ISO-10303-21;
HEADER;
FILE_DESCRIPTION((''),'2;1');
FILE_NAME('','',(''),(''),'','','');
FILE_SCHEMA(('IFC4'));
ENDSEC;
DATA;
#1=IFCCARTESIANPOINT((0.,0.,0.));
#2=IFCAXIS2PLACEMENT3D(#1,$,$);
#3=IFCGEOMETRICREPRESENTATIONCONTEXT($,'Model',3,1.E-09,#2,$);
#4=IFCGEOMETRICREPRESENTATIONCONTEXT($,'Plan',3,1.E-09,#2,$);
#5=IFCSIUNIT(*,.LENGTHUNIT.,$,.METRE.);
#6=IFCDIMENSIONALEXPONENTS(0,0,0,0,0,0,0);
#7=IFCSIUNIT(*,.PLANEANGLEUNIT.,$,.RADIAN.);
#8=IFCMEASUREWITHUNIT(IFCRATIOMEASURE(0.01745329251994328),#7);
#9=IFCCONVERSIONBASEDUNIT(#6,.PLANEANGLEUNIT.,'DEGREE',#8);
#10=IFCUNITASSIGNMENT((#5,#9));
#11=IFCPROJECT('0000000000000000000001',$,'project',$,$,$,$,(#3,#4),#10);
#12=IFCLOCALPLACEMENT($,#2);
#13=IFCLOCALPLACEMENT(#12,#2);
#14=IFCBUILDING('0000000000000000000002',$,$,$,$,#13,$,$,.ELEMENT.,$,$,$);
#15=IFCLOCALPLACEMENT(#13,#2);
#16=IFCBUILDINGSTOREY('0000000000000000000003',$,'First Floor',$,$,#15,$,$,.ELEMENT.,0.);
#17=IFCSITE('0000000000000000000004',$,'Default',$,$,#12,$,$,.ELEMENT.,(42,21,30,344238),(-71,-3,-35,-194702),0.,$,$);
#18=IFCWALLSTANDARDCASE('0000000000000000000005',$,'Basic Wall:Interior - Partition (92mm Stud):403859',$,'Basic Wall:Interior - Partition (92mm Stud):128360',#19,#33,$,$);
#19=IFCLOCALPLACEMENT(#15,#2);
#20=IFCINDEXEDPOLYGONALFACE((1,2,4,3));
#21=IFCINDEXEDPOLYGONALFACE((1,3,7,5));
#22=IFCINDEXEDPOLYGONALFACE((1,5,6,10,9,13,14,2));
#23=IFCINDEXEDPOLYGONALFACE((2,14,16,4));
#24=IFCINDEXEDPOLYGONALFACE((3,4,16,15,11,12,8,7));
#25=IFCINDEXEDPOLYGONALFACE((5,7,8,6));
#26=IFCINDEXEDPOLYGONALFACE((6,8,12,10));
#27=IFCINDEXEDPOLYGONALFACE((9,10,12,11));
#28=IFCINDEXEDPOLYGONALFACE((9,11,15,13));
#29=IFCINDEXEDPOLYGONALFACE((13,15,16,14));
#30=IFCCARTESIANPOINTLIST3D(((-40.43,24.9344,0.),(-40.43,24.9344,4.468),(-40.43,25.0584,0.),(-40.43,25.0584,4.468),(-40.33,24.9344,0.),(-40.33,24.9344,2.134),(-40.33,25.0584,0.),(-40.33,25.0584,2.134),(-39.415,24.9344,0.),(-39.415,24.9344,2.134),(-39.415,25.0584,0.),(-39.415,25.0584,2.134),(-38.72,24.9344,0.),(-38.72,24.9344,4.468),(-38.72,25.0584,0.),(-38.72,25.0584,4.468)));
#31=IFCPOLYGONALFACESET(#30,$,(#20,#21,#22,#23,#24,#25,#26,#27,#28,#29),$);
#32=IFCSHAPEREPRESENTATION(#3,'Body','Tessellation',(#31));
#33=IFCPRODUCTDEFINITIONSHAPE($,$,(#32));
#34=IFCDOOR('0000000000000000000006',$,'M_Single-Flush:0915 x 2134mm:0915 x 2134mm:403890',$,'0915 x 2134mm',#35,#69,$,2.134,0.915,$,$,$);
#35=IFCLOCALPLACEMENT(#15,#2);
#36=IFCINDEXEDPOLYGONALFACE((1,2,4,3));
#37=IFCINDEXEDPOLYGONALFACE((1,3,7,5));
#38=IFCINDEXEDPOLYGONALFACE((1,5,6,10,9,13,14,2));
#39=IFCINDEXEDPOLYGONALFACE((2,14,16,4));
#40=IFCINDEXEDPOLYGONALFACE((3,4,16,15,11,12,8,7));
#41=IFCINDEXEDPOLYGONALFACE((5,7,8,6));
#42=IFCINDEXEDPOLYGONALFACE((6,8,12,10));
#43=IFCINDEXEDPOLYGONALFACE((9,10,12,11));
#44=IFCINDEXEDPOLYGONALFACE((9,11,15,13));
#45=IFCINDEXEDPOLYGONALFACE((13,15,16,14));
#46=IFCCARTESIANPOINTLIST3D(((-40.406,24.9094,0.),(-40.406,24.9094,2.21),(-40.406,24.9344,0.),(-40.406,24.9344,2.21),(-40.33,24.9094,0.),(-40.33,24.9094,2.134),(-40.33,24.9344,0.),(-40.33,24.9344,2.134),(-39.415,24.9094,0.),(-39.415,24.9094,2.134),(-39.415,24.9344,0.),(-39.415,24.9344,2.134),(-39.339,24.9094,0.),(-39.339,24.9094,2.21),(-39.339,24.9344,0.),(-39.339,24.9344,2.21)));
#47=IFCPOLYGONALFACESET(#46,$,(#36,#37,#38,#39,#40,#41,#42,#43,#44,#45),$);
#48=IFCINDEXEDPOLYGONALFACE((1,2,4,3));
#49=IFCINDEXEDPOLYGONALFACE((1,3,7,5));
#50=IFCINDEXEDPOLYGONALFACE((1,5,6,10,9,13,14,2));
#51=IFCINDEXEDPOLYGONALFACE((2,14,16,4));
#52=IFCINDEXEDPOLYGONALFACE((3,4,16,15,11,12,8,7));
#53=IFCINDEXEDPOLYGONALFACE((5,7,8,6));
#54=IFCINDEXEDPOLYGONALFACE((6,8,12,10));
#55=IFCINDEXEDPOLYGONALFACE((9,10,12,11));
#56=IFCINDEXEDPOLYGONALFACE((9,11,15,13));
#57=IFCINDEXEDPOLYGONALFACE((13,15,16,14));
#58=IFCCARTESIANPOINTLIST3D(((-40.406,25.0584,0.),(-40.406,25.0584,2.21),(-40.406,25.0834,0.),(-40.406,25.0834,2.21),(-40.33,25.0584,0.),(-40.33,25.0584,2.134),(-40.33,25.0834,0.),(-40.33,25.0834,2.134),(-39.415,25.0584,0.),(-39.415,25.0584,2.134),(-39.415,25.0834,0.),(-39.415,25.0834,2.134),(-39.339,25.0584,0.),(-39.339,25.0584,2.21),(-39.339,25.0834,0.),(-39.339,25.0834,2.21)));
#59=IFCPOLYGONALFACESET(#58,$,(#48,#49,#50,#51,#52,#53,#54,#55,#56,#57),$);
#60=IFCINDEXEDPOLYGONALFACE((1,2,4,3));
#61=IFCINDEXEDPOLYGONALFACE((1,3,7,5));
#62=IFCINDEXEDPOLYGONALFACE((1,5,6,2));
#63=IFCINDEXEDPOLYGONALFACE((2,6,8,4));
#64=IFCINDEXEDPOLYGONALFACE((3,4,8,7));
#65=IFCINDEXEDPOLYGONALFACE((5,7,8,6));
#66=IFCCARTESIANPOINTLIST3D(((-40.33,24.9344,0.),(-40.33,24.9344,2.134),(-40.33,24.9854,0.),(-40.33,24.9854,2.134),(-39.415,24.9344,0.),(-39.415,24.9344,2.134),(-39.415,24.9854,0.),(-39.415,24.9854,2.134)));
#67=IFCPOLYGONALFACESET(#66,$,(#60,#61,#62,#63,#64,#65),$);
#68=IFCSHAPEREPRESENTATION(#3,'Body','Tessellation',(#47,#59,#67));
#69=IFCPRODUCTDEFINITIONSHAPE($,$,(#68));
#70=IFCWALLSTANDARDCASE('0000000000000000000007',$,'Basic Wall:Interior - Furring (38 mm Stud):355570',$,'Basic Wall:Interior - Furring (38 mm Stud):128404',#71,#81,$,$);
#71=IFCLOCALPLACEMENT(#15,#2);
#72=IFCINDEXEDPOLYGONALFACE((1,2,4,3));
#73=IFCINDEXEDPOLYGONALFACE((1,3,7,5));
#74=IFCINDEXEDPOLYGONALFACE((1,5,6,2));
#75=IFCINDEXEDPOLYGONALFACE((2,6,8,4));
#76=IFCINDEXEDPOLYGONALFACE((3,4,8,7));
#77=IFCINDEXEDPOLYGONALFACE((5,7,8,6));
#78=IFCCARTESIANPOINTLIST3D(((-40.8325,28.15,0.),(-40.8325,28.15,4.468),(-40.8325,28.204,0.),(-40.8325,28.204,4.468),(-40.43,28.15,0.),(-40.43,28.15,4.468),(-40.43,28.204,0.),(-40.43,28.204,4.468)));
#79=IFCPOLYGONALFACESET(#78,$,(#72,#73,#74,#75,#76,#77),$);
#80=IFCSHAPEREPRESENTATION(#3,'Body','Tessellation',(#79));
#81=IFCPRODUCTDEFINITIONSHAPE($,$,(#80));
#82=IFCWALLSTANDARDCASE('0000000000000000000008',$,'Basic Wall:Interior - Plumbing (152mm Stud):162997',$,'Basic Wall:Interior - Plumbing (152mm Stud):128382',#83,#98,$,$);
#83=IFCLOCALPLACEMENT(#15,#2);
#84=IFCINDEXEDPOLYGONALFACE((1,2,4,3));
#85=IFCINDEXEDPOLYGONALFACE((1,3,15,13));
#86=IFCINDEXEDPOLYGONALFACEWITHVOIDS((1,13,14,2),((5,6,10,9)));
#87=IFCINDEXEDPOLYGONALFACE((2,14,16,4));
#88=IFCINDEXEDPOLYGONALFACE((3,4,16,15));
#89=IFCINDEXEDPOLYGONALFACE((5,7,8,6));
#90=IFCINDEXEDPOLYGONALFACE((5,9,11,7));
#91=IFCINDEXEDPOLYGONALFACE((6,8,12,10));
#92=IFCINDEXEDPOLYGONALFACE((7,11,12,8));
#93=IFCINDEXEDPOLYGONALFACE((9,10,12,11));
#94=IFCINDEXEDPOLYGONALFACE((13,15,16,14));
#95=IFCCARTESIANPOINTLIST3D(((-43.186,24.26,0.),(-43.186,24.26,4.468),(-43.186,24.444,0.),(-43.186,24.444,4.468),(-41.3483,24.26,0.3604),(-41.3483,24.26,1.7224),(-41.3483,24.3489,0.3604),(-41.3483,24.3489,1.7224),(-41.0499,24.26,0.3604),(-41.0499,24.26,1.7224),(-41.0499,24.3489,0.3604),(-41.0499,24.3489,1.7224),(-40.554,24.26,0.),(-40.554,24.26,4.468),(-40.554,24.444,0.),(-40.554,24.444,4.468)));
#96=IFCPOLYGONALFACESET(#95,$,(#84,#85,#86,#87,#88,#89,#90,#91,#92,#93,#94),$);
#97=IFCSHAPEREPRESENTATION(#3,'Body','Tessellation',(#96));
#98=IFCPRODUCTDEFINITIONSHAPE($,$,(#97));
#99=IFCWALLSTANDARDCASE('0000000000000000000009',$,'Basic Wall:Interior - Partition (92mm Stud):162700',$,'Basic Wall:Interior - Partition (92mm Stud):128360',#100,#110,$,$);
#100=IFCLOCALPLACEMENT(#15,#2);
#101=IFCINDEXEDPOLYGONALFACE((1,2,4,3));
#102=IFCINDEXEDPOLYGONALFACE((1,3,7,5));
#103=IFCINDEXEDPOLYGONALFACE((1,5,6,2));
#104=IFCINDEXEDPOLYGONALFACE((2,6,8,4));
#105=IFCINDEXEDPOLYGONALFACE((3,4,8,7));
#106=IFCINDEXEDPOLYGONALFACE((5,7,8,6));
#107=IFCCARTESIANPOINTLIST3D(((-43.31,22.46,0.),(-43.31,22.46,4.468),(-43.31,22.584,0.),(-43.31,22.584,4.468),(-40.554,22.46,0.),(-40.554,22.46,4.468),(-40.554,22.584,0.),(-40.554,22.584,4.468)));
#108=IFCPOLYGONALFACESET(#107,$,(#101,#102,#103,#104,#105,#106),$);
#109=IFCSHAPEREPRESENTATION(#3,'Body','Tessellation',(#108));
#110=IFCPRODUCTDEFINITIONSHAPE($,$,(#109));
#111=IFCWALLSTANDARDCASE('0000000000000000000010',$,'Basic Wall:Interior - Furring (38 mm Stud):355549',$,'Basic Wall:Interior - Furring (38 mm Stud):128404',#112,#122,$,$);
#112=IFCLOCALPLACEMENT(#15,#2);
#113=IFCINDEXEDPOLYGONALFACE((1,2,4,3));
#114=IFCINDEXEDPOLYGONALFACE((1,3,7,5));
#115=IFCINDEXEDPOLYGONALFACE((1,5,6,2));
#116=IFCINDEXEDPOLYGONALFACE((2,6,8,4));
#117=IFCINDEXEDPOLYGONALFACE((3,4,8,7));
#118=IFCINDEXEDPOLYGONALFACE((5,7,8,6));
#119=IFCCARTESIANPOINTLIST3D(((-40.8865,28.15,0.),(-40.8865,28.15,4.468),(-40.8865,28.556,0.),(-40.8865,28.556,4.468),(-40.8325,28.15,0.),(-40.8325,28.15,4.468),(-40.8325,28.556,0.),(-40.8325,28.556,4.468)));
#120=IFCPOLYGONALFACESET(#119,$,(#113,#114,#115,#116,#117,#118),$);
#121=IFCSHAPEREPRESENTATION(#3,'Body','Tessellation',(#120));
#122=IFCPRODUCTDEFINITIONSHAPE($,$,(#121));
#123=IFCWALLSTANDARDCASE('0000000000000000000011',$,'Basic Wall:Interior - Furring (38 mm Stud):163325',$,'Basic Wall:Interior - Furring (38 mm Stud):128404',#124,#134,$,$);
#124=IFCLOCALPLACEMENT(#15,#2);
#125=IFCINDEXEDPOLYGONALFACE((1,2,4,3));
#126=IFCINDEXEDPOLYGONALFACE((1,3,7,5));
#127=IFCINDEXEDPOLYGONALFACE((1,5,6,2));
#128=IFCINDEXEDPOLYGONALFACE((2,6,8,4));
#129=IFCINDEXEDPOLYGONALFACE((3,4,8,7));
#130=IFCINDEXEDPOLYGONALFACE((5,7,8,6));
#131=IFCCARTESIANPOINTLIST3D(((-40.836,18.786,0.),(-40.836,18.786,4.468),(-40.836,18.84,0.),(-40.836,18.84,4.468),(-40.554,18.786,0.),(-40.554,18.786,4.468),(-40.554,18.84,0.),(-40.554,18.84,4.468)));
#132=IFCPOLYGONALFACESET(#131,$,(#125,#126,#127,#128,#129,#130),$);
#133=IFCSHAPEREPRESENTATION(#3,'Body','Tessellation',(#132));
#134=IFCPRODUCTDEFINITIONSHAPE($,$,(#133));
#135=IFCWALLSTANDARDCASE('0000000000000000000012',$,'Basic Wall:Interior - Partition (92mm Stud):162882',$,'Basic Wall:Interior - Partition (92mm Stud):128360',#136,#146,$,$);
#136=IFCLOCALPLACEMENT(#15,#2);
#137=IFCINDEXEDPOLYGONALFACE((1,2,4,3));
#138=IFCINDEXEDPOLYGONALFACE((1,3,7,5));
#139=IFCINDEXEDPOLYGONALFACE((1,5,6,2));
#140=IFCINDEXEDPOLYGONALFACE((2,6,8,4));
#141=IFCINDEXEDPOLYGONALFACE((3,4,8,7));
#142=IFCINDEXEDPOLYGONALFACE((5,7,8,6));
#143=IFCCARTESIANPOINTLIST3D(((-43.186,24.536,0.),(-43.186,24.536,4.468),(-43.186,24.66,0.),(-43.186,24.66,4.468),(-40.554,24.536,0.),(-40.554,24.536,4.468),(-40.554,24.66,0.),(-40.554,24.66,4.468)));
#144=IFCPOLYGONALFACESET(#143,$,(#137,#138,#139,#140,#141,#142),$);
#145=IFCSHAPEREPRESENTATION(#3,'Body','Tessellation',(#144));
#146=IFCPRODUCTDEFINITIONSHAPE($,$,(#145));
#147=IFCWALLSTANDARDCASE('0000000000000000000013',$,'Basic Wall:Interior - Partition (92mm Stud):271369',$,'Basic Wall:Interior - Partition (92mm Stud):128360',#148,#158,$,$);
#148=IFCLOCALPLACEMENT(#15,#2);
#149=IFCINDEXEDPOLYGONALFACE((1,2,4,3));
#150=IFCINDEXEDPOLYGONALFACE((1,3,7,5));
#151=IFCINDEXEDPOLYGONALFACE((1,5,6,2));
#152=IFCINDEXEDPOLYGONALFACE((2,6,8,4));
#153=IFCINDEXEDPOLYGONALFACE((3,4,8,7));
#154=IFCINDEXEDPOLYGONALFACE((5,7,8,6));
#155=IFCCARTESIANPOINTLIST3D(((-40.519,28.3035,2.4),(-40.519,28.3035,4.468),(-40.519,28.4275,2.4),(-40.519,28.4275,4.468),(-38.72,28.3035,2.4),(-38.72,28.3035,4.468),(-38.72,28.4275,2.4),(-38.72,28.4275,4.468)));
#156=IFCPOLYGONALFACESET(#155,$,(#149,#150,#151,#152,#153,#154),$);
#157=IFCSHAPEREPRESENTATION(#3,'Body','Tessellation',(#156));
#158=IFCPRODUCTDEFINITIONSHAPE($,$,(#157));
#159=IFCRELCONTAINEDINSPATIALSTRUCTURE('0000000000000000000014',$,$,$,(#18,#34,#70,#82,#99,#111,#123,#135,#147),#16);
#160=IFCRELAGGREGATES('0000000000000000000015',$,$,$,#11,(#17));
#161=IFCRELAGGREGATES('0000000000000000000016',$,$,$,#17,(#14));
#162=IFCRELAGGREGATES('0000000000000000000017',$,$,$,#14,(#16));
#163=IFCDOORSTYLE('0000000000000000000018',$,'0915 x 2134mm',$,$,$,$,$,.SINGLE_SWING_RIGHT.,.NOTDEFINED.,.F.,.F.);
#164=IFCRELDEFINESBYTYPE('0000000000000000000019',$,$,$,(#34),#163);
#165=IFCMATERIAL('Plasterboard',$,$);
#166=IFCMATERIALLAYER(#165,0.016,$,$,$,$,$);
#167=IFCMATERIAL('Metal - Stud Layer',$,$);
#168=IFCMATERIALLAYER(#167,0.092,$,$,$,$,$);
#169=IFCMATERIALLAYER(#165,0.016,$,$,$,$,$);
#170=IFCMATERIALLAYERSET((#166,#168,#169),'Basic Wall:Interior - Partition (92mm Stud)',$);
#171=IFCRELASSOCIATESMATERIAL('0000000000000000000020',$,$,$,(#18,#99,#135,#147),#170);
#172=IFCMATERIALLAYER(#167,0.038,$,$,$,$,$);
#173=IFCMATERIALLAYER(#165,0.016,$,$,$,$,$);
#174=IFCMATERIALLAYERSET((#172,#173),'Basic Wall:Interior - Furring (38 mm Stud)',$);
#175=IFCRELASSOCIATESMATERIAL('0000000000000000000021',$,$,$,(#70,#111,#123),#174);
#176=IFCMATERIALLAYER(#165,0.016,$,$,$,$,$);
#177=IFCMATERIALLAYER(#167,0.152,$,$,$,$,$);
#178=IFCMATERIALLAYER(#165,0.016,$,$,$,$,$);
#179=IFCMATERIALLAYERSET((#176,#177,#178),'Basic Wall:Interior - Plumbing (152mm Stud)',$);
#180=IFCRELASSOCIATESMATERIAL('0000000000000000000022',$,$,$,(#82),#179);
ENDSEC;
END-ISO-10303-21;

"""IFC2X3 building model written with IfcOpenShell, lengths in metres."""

from ifc_helpers import new_model, entity, si_unit, converted_unit, frame, frame_2d, origin, origin_2d_with_axis, place, context, project, spatial, polyline, rectangle, outline, extrude, source, transform, mapped, material, layer, layer_set, layer_usage, type_object, type_shapes, element, fill, save


model = new_model("IFC2X3")

# Units and contexts
model_context = context("Model", 3, precision=1e-09, world=origin())
plan_context = context("Plan", 3, precision=1e-09, world=origin())
ifc_project = project(units=[si_unit("LENGTHUNIT", "METRE"), converted_unit("PLANEANGLEUNIT", "DEGREE", entity("IfcRatioMeasure", 0.01745329251994328), si_unit("PLANEANGLEUNIT", "RADIAN"), dimensions=[0, 0, 0, 0, 0, 0, 0])], contexts=[model_context, plan_context])

# Site, building, storey
site_placement = place(None, origin())
site = spatial("IfcSite", under=ifc_project, at=site_placement, Name="Default", CompositionType="ELEMENT", RefLatitude=(42, 21, 30, 344238), RefLongitude=(-71, -3, -35, -194702), RefElevation=0.0)
building_placement = place(site_placement, origin())
building = spatial("IfcBuilding", under=site, at=building_placement, CompositionType="ELEMENT")
storey_placement = place(building_placement, origin())
storey = spatial("IfcBuildingStorey", under=building, at=storey_placement, Name="First Floor", CompositionType="ELEMENT", Elevation=0.0)

# Shared definitions
ifc_material_1 = material(Name="Plasterboard")
ifc_layer_1 = layer(ifc_material_1, 0.016)
ifc_material_2 = material(Name="Metal - Stud Layer")
ifc_layer_2 = layer(ifc_material_2, 0.092)
ifc_layer_3 = layer(ifc_material_1, 0.016)
ifc_layer_set_1 = layer_set([ifc_layer_1, ifc_layer_2, ifc_layer_3], Name="Basic Wall:Interior - Partition (92mm Stud)")
ifc_layer_usage_1 = layer_usage(ifc_layer_set_1, "AXIS2", "NEGATIVE", 0.062)
door_style_1 = type_object("IfcDoorStyle", Name="0915 x 2134mm", ConstructionType="NOTDEFINED", OperationType="SINGLE_SWING_RIGHT", ParameterTakesPrecedence=False, Sizeable=False)
shared_shape_1 = source(origin(), model_context, "Body", "SweptSolid", [
    extrude(outline(polyline([(-0.5335, -1.124), (0.5335, -1.124), (0.5335, 1.086), (0.4575, 1.086), (0.4575, -1.048), (-0.4575, -1.048), (-0.4575, 1.086), (-0.5335, 1.086), (-0.5335, -1.124)])), frame((0.4575, 0.124, 1.086), z_axis=(0.0, 1.0, 0.0), x_axis=(1.0, 0.0, 0.0)), (0.0, 0.0, 1.0), 0.025),
    extrude(outline(polyline([(-1.124, -0.5335), (1.086, -0.5335), (1.086, -0.4575), (-1.048, -0.4575), (-1.048, 0.4575), (1.086, 0.4575), (1.086, 0.5335), (-1.124, 0.5335), (-1.124, -0.5335)])), frame((0.4575, -0.025, 1.086), z_axis=(0.0, 1.0, 0.0), x_axis=(0.0, 0.0, -1.0)), (0.0, 0.0, 1.0), 0.025),
    extrude(rectangle(XDim=0.051, YDim=0.915, at=origin_2d_with_axis()), frame((0.4575, 0.0985, 0.0), z_axis=(0.0, 0.0, 1.0), x_axis=(0.0, 1.0, 0.0)), (0.0, 0.0, 1.0), 2.134),
])
type_shapes(door_style_1, [shared_shape_1])

# Shared definitions
ifc_layer_4 = layer(ifc_material_2, 0.038)
ifc_layer_5 = layer(ifc_material_1, 0.016)
ifc_layer_set_2 = layer_set([ifc_layer_4, ifc_layer_5], Name="Basic Wall:Interior - Furring (38 mm Stud)")
ifc_layer_usage_2 = layer_usage(ifc_layer_set_2, "AXIS2", "NEGATIVE", 0.027)

# Wall, opening, door
wall_1_placement = place(storey_placement, frame((-40.43, 24.9964, 0.0)))
wall_1 = element("IfcWallStandardCase", 1, at=wall_1_placement, inside=storey, material=ifc_layer_usage_1, Name="Basic Wall:Interior - Partition (92mm Stud):403859", ObjectType="Basic Wall:Interior - Partition (92mm Stud):128360", context=model_context, shape_type="SweptSolid", body=[
    extrude(rectangle(XDim=1.71, YDim=0.124, at=frame_2d((0.855, 0.0), x_axis=(-1.0, 0.0))), origin(), (0.0, 0.0, 1.0), 4.468),
])
opening_1_placement = place(wall_1_placement, frame((1.015, 0.062, 0.0)))
opening_1 = element("IfcOpeningElement", 2, at=opening_1_placement, cuts=wall_1, ObjectType="Opening", context=model_context, shape_type="SweptSolid", body=[
    extrude(rectangle(XDim=0.915, YDim=2.134, at=frame_2d((1.067, 0.4575), x_axis=(0.0, 1.0))), frame((0.0, 0.0, 0.0), z_axis=(0.0, -1.0, 0.0), x_axis=(0.0, 0.0, 1.0)), (0.0, 0.0, 1.0), 0.124),
])
door_1_placement = place(opening_1_placement, frame((0.0, 0.0, 0.0), z_axis=(0.0, 0.0, 1.0), x_axis=(-1.0, 0.0, 0.0)))
door_1 = element("IfcDoor", 3, at=door_1_placement, inside=storey, type_object=door_style_1, Name="M_Single-Flush:0915 x 2134mm:0915 x 2134mm:403890", ObjectType="0915 x 2134mm", OverallHeight=2.134, OverallWidth=0.915, context=model_context, shape_type="MappedRepresentation", body=[
    mapped(shared_shape_1, transform((0.0, 0.0, 0.0), scale=1.0)),
])
fill(opening_1, door_1)

# Wall
wall_2_placement = place(storey_placement, frame((-40.8325, 28.177, 0.0)))
element("IfcWallStandardCase", 4, at=wall_2_placement, inside=storey, material=ifc_layer_usage_2, Name="Basic Wall:Interior - Furring (38 mm Stud):355570", ObjectType="Basic Wall:Interior - Furring (38 mm Stud):128404", context=model_context, shape_type="SweptSolid", body=[
    extrude(rectangle(XDim=0.4025, YDim=0.054, at=frame_2d((0.2013, 0.0), x_axis=(-1.0, 0.0))), origin(), (0.0, 0.0, 1.0), 4.468),
])

# Wall, opening
ifc_layer_6 = layer(ifc_material_1, 0.016)
ifc_layer_7 = layer(ifc_material_2, 0.152)
ifc_layer_8 = layer(ifc_material_1, 0.016)
ifc_layer_set_3 = layer_set([ifc_layer_6, ifc_layer_7, ifc_layer_8], Name="Basic Wall:Interior - Plumbing (152mm Stud)")
ifc_layer_usage_3 = layer_usage(ifc_layer_set_3, "AXIS2", "NEGATIVE", 0.092)
wall_3_placement = place(storey_placement, frame((-40.554, 24.352, 0.0), z_axis=(0.0, 0.0, 1.0), x_axis=(-1.0, 0.0, 0.0)))
wall_3 = element("IfcWallStandardCase", 5, at=wall_3_placement, inside=storey, material=ifc_layer_usage_3, Name="Basic Wall:Interior - Plumbing (152mm Stud):162997", ObjectType="Basic Wall:Interior - Plumbing (152mm Stud):128382", context=model_context, shape_type="SweptSolid", body=[
    extrude(rectangle(XDim=2.632, YDim=0.184, at=frame_2d((1.316, 0.0), x_axis=(-1.0, 0.0))), origin(), (0.0, 0.0, 1.0), 4.468),
])
opening_2_placement = place(wall_3_placement, origin())
element("IfcOpeningElement", 6, at=opening_2_placement, cuts=wall_3, ObjectType="Opening", context=model_context, shape_type="SweptSolid", body=[
    extrude(rectangle(XDim=1.3621, YDim=0.2984, at=frame_2d((0.0, 0.0), x_axis=(0.0, 1.0))), frame((0.6451, 0.0031, 1.0414), z_axis=(0.0, 1.0, 0.0), x_axis=(1.0, 0.0, 0.0)), (0.0, 0.0, 1.0), 0.1524),
])

# Walls
wall_4_placement = place(storey_placement, frame((-40.554, 22.522, 0.0), z_axis=(0.0, 0.0, 1.0), x_axis=(-1.0, 0.0, 0.0)))
element("IfcWallStandardCase", 7, at=wall_4_placement, inside=storey, material=ifc_layer_usage_1, Name="Basic Wall:Interior - Partition (92mm Stud):162700", ObjectType="Basic Wall:Interior - Partition (92mm Stud):128360", context=model_context, shape_type="SweptSolid", body=[
    extrude(rectangle(XDim=2.756, YDim=0.124, at=frame_2d((1.378, 0.0), x_axis=(-1.0, 0.0))), origin(), (0.0, 0.0, 1.0), 4.468),
])
wall_5_placement = place(storey_placement, frame((-40.8595, 28.556, 0.0), z_axis=(0.0, 0.0, 1.0), x_axis=(0.0, -1.0, 0.0)))
element("IfcWallStandardCase", 8, at=wall_5_placement, inside=storey, material=ifc_layer_usage_2, Name="Basic Wall:Interior - Furring (38 mm Stud):355549", ObjectType="Basic Wall:Interior - Furring (38 mm Stud):128404", context=model_context, shape_type="SweptSolid", body=[
    extrude(rectangle(XDim=0.406, YDim=0.054, at=frame_2d((0.203, 0.0), x_axis=(-1.0, 0.0))), origin(), (0.0, 0.0, 1.0), 4.468),
])
ifc_layer_usage_4 = layer_usage(ifc_layer_set_2, "AXIS2", "POSITIVE", -0.027)
wall_6_placement = place(storey_placement, frame((-40.836, 18.813, 0.0)))
element("IfcWallStandardCase", 9, at=wall_6_placement, inside=storey, material=ifc_layer_usage_4, Name="Basic Wall:Interior - Furring (38 mm Stud):163325", ObjectType="Basic Wall:Interior - Furring (38 mm Stud):128404", context=model_context, shape_type="SweptSolid", body=[
    extrude(rectangle(XDim=0.282, YDim=0.054, at=frame_2d((0.141, 0.0), x_axis=(-1.0, 0.0))), origin(), (0.0, 0.0, 1.0), 4.468),
])
wall_7_placement = place(storey_placement, frame((-43.186, 24.598, 0.0)))
element("IfcWallStandardCase", 10, at=wall_7_placement, inside=storey, material=ifc_layer_usage_1, Name="Basic Wall:Interior - Partition (92mm Stud):162882", ObjectType="Basic Wall:Interior - Partition (92mm Stud):128360", context=model_context, shape_type="SweptSolid", body=[
    extrude(rectangle(XDim=2.632, YDim=0.124, at=frame_2d((1.316, 0.0), x_axis=(-1.0, 0.0))), origin(), (0.0, 0.0, 1.0), 4.468),
])
wall_8_placement = place(storey_placement, frame((-38.72, 28.3655, 2.4), z_axis=(0.0, 0.0, 1.0), x_axis=(-1.0, 0.0, 0.0)))
element("IfcWallStandardCase", 11, at=wall_8_placement, inside=storey, material=ifc_layer_usage_1, Name="Basic Wall:Interior - Partition (92mm Stud):271369", ObjectType="Basic Wall:Interior - Partition (92mm Stud):128360", context=model_context, shape_type="SweptSolid", body=[
    extrude(rectangle(XDim=1.799, YDim=0.124, at=frame_2d((0.8995, 0.0), x_axis=(-1.0, 0.0))), origin(), (0.0, 0.0, 1.0), 2.068),
])

save(model, "model.ifc")
